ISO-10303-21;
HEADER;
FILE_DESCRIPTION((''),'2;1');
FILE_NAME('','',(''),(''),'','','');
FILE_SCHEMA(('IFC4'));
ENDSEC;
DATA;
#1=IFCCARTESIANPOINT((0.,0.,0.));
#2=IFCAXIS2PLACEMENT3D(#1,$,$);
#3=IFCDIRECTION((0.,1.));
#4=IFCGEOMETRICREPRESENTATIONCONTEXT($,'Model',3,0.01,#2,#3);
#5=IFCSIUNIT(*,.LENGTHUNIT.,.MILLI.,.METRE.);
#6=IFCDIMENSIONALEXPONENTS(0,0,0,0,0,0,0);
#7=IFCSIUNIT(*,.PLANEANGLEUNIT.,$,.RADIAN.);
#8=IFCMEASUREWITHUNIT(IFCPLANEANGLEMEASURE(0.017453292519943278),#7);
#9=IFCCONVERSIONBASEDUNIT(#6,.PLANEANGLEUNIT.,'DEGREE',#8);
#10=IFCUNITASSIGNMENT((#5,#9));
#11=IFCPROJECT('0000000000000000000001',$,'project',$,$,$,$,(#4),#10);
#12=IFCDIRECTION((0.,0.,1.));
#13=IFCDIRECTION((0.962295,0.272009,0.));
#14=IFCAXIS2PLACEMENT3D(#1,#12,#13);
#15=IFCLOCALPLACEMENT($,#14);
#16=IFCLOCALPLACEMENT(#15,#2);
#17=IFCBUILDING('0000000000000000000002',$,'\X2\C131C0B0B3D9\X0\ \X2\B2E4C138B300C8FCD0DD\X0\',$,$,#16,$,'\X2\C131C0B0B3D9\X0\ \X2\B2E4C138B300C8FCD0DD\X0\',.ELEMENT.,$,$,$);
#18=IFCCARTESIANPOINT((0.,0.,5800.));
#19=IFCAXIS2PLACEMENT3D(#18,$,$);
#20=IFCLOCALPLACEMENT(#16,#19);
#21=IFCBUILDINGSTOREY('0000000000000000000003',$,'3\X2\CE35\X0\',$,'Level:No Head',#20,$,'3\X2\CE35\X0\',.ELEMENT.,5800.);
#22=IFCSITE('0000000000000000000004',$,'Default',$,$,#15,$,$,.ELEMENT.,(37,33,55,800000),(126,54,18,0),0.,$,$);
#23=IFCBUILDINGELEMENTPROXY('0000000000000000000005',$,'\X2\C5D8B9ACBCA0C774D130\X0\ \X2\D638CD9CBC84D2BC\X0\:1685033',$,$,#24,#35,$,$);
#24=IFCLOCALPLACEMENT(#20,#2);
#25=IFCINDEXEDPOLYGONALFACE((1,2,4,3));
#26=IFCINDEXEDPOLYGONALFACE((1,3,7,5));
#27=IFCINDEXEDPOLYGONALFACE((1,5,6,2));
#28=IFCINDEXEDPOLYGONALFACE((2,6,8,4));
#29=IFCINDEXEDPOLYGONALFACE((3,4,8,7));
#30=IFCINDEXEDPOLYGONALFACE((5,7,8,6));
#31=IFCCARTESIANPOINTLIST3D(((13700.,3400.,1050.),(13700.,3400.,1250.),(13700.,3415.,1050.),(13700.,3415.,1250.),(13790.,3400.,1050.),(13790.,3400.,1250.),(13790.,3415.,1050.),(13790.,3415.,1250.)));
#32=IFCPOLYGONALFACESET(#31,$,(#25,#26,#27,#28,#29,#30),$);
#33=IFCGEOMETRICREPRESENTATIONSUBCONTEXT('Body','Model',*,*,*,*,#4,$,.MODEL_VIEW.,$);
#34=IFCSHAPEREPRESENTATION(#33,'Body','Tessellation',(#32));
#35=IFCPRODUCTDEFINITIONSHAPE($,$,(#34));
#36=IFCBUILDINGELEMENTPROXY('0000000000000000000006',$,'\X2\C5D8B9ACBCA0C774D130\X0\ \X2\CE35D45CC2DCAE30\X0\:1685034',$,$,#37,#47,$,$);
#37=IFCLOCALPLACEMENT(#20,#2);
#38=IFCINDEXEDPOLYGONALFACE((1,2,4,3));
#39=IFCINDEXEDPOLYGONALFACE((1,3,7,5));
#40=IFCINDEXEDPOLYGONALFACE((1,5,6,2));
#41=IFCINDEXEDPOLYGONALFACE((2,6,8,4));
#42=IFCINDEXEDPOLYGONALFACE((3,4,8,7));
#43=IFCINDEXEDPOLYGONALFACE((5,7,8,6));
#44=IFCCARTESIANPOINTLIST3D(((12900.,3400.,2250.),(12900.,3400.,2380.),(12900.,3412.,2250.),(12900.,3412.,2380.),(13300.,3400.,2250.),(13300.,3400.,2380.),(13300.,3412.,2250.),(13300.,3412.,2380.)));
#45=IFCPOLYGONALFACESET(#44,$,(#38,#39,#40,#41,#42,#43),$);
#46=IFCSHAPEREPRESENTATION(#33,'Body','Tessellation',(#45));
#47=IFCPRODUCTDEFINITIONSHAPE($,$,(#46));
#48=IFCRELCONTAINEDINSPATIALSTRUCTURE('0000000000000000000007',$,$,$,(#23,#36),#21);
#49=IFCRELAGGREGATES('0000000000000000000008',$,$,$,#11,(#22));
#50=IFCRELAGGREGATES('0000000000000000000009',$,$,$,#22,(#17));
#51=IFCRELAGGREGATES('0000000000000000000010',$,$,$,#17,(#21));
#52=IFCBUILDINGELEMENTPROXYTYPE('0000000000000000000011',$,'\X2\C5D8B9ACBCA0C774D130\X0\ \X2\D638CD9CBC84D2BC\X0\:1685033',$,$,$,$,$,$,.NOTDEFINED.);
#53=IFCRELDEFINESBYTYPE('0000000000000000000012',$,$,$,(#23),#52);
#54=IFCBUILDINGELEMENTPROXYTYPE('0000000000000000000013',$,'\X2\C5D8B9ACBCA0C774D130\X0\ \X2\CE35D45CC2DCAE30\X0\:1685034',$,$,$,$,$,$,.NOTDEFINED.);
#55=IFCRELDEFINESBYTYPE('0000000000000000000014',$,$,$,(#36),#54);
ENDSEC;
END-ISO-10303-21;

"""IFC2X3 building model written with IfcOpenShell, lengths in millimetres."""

from ifc_helpers import new_model, entity, si_unit, converted_unit, direction, frame, frame_2d, origin, place, context, subcontext, project, spatial, rectangle, extrude, type_object, element, save


model = new_model("IFC2X3")

# Units and contexts
model_context = context("Model", 3, precision=0.01, world=origin(), true_north=direction((0.0, 1.0)))
body_context = subcontext(model_context, "Body", "Model", "MODEL_VIEW")
ifc_project = project(units=[si_unit("LENGTHUNIT", "METRE", prefix="MILLI"), converted_unit("PLANEANGLEUNIT", "DEGREE", entity("IfcPlaneAngleMeasure", 0.017453292519943278), si_unit("PLANEANGLEUNIT", "RADIAN"), dimensions=[0, 0, 0, 0, 0, 0, 0])], contexts=[model_context])

# Site, building, storey
site_placement = place(None, frame((0.0, 0.0, 0.0), z_axis=(0.0, 0.0, 1.0), x_axis=(0.962295, 0.272009, 0.0)))
site = spatial("IfcSite", under=ifc_project, at=site_placement, Name="Default", CompositionType="ELEMENT", RefLatitude=(37, 33, 55, 800000), RefLongitude=(126, 54, 18, 0), RefElevation=0.0)
building_placement = place(site_placement, origin())
building = spatial("IfcBuilding", under=site, at=building_placement, Name="성산동 다세대주택", LongName="성산동 다세대주택", CompositionType="ELEMENT")
storey_placement = place(building_placement, frame((0.0, 0.0, 5800.0)))
storey = spatial("IfcBuildingStorey", under=building, at=storey_placement, Name="3층", ObjectType="Level:No Head", LongName="3층", CompositionType="ELEMENT", Elevation=5800.0)

# Building element proxies
building_element_proxy_type_1 = type_object("IfcBuildingElementProxyType", Name="엘리베이터 호출버튼:1685033", PredefinedType="NOTDEFINED")
proxy_1_placement = place(storey_placement, origin())
element("IfcBuildingElementProxy", 1, at=proxy_1_placement, inside=storey, type_object=building_element_proxy_type_1, Name="엘리베이터 호출버튼:1685033", context=body_context, shape_type="SweptSolid", body=[
    extrude(rectangle(XDim=90.0, YDim=15.0, at=frame_2d((0.0, 0.0), x_axis=(1.0, 0.0))), frame((13745.0, 3407.5, 1050.0)), (0.0, 0.0, 1.0), 200.0),
])
building_element_proxy_type_2 = type_object("IfcBuildingElementProxyType", Name="엘리베이터 층표시기:1685034", PredefinedType="NOTDEFINED")
proxy_2_placement = place(storey_placement, origin())
element("IfcBuildingElementProxy", 2, at=proxy_2_placement, inside=storey, type_object=building_element_proxy_type_2, Name="엘리베이터 층표시기:1685034", context=body_context, shape_type="SweptSolid", body=[
    extrude(rectangle(XDim=400.0, YDim=12.0, at=frame_2d((0.0, 0.0), x_axis=(1.0, 0.0))), frame((13100.0, 3406.0, 2250.0)), (0.0, 0.0, 1.0), 130.0),
])

save(model, "model.ifc")
